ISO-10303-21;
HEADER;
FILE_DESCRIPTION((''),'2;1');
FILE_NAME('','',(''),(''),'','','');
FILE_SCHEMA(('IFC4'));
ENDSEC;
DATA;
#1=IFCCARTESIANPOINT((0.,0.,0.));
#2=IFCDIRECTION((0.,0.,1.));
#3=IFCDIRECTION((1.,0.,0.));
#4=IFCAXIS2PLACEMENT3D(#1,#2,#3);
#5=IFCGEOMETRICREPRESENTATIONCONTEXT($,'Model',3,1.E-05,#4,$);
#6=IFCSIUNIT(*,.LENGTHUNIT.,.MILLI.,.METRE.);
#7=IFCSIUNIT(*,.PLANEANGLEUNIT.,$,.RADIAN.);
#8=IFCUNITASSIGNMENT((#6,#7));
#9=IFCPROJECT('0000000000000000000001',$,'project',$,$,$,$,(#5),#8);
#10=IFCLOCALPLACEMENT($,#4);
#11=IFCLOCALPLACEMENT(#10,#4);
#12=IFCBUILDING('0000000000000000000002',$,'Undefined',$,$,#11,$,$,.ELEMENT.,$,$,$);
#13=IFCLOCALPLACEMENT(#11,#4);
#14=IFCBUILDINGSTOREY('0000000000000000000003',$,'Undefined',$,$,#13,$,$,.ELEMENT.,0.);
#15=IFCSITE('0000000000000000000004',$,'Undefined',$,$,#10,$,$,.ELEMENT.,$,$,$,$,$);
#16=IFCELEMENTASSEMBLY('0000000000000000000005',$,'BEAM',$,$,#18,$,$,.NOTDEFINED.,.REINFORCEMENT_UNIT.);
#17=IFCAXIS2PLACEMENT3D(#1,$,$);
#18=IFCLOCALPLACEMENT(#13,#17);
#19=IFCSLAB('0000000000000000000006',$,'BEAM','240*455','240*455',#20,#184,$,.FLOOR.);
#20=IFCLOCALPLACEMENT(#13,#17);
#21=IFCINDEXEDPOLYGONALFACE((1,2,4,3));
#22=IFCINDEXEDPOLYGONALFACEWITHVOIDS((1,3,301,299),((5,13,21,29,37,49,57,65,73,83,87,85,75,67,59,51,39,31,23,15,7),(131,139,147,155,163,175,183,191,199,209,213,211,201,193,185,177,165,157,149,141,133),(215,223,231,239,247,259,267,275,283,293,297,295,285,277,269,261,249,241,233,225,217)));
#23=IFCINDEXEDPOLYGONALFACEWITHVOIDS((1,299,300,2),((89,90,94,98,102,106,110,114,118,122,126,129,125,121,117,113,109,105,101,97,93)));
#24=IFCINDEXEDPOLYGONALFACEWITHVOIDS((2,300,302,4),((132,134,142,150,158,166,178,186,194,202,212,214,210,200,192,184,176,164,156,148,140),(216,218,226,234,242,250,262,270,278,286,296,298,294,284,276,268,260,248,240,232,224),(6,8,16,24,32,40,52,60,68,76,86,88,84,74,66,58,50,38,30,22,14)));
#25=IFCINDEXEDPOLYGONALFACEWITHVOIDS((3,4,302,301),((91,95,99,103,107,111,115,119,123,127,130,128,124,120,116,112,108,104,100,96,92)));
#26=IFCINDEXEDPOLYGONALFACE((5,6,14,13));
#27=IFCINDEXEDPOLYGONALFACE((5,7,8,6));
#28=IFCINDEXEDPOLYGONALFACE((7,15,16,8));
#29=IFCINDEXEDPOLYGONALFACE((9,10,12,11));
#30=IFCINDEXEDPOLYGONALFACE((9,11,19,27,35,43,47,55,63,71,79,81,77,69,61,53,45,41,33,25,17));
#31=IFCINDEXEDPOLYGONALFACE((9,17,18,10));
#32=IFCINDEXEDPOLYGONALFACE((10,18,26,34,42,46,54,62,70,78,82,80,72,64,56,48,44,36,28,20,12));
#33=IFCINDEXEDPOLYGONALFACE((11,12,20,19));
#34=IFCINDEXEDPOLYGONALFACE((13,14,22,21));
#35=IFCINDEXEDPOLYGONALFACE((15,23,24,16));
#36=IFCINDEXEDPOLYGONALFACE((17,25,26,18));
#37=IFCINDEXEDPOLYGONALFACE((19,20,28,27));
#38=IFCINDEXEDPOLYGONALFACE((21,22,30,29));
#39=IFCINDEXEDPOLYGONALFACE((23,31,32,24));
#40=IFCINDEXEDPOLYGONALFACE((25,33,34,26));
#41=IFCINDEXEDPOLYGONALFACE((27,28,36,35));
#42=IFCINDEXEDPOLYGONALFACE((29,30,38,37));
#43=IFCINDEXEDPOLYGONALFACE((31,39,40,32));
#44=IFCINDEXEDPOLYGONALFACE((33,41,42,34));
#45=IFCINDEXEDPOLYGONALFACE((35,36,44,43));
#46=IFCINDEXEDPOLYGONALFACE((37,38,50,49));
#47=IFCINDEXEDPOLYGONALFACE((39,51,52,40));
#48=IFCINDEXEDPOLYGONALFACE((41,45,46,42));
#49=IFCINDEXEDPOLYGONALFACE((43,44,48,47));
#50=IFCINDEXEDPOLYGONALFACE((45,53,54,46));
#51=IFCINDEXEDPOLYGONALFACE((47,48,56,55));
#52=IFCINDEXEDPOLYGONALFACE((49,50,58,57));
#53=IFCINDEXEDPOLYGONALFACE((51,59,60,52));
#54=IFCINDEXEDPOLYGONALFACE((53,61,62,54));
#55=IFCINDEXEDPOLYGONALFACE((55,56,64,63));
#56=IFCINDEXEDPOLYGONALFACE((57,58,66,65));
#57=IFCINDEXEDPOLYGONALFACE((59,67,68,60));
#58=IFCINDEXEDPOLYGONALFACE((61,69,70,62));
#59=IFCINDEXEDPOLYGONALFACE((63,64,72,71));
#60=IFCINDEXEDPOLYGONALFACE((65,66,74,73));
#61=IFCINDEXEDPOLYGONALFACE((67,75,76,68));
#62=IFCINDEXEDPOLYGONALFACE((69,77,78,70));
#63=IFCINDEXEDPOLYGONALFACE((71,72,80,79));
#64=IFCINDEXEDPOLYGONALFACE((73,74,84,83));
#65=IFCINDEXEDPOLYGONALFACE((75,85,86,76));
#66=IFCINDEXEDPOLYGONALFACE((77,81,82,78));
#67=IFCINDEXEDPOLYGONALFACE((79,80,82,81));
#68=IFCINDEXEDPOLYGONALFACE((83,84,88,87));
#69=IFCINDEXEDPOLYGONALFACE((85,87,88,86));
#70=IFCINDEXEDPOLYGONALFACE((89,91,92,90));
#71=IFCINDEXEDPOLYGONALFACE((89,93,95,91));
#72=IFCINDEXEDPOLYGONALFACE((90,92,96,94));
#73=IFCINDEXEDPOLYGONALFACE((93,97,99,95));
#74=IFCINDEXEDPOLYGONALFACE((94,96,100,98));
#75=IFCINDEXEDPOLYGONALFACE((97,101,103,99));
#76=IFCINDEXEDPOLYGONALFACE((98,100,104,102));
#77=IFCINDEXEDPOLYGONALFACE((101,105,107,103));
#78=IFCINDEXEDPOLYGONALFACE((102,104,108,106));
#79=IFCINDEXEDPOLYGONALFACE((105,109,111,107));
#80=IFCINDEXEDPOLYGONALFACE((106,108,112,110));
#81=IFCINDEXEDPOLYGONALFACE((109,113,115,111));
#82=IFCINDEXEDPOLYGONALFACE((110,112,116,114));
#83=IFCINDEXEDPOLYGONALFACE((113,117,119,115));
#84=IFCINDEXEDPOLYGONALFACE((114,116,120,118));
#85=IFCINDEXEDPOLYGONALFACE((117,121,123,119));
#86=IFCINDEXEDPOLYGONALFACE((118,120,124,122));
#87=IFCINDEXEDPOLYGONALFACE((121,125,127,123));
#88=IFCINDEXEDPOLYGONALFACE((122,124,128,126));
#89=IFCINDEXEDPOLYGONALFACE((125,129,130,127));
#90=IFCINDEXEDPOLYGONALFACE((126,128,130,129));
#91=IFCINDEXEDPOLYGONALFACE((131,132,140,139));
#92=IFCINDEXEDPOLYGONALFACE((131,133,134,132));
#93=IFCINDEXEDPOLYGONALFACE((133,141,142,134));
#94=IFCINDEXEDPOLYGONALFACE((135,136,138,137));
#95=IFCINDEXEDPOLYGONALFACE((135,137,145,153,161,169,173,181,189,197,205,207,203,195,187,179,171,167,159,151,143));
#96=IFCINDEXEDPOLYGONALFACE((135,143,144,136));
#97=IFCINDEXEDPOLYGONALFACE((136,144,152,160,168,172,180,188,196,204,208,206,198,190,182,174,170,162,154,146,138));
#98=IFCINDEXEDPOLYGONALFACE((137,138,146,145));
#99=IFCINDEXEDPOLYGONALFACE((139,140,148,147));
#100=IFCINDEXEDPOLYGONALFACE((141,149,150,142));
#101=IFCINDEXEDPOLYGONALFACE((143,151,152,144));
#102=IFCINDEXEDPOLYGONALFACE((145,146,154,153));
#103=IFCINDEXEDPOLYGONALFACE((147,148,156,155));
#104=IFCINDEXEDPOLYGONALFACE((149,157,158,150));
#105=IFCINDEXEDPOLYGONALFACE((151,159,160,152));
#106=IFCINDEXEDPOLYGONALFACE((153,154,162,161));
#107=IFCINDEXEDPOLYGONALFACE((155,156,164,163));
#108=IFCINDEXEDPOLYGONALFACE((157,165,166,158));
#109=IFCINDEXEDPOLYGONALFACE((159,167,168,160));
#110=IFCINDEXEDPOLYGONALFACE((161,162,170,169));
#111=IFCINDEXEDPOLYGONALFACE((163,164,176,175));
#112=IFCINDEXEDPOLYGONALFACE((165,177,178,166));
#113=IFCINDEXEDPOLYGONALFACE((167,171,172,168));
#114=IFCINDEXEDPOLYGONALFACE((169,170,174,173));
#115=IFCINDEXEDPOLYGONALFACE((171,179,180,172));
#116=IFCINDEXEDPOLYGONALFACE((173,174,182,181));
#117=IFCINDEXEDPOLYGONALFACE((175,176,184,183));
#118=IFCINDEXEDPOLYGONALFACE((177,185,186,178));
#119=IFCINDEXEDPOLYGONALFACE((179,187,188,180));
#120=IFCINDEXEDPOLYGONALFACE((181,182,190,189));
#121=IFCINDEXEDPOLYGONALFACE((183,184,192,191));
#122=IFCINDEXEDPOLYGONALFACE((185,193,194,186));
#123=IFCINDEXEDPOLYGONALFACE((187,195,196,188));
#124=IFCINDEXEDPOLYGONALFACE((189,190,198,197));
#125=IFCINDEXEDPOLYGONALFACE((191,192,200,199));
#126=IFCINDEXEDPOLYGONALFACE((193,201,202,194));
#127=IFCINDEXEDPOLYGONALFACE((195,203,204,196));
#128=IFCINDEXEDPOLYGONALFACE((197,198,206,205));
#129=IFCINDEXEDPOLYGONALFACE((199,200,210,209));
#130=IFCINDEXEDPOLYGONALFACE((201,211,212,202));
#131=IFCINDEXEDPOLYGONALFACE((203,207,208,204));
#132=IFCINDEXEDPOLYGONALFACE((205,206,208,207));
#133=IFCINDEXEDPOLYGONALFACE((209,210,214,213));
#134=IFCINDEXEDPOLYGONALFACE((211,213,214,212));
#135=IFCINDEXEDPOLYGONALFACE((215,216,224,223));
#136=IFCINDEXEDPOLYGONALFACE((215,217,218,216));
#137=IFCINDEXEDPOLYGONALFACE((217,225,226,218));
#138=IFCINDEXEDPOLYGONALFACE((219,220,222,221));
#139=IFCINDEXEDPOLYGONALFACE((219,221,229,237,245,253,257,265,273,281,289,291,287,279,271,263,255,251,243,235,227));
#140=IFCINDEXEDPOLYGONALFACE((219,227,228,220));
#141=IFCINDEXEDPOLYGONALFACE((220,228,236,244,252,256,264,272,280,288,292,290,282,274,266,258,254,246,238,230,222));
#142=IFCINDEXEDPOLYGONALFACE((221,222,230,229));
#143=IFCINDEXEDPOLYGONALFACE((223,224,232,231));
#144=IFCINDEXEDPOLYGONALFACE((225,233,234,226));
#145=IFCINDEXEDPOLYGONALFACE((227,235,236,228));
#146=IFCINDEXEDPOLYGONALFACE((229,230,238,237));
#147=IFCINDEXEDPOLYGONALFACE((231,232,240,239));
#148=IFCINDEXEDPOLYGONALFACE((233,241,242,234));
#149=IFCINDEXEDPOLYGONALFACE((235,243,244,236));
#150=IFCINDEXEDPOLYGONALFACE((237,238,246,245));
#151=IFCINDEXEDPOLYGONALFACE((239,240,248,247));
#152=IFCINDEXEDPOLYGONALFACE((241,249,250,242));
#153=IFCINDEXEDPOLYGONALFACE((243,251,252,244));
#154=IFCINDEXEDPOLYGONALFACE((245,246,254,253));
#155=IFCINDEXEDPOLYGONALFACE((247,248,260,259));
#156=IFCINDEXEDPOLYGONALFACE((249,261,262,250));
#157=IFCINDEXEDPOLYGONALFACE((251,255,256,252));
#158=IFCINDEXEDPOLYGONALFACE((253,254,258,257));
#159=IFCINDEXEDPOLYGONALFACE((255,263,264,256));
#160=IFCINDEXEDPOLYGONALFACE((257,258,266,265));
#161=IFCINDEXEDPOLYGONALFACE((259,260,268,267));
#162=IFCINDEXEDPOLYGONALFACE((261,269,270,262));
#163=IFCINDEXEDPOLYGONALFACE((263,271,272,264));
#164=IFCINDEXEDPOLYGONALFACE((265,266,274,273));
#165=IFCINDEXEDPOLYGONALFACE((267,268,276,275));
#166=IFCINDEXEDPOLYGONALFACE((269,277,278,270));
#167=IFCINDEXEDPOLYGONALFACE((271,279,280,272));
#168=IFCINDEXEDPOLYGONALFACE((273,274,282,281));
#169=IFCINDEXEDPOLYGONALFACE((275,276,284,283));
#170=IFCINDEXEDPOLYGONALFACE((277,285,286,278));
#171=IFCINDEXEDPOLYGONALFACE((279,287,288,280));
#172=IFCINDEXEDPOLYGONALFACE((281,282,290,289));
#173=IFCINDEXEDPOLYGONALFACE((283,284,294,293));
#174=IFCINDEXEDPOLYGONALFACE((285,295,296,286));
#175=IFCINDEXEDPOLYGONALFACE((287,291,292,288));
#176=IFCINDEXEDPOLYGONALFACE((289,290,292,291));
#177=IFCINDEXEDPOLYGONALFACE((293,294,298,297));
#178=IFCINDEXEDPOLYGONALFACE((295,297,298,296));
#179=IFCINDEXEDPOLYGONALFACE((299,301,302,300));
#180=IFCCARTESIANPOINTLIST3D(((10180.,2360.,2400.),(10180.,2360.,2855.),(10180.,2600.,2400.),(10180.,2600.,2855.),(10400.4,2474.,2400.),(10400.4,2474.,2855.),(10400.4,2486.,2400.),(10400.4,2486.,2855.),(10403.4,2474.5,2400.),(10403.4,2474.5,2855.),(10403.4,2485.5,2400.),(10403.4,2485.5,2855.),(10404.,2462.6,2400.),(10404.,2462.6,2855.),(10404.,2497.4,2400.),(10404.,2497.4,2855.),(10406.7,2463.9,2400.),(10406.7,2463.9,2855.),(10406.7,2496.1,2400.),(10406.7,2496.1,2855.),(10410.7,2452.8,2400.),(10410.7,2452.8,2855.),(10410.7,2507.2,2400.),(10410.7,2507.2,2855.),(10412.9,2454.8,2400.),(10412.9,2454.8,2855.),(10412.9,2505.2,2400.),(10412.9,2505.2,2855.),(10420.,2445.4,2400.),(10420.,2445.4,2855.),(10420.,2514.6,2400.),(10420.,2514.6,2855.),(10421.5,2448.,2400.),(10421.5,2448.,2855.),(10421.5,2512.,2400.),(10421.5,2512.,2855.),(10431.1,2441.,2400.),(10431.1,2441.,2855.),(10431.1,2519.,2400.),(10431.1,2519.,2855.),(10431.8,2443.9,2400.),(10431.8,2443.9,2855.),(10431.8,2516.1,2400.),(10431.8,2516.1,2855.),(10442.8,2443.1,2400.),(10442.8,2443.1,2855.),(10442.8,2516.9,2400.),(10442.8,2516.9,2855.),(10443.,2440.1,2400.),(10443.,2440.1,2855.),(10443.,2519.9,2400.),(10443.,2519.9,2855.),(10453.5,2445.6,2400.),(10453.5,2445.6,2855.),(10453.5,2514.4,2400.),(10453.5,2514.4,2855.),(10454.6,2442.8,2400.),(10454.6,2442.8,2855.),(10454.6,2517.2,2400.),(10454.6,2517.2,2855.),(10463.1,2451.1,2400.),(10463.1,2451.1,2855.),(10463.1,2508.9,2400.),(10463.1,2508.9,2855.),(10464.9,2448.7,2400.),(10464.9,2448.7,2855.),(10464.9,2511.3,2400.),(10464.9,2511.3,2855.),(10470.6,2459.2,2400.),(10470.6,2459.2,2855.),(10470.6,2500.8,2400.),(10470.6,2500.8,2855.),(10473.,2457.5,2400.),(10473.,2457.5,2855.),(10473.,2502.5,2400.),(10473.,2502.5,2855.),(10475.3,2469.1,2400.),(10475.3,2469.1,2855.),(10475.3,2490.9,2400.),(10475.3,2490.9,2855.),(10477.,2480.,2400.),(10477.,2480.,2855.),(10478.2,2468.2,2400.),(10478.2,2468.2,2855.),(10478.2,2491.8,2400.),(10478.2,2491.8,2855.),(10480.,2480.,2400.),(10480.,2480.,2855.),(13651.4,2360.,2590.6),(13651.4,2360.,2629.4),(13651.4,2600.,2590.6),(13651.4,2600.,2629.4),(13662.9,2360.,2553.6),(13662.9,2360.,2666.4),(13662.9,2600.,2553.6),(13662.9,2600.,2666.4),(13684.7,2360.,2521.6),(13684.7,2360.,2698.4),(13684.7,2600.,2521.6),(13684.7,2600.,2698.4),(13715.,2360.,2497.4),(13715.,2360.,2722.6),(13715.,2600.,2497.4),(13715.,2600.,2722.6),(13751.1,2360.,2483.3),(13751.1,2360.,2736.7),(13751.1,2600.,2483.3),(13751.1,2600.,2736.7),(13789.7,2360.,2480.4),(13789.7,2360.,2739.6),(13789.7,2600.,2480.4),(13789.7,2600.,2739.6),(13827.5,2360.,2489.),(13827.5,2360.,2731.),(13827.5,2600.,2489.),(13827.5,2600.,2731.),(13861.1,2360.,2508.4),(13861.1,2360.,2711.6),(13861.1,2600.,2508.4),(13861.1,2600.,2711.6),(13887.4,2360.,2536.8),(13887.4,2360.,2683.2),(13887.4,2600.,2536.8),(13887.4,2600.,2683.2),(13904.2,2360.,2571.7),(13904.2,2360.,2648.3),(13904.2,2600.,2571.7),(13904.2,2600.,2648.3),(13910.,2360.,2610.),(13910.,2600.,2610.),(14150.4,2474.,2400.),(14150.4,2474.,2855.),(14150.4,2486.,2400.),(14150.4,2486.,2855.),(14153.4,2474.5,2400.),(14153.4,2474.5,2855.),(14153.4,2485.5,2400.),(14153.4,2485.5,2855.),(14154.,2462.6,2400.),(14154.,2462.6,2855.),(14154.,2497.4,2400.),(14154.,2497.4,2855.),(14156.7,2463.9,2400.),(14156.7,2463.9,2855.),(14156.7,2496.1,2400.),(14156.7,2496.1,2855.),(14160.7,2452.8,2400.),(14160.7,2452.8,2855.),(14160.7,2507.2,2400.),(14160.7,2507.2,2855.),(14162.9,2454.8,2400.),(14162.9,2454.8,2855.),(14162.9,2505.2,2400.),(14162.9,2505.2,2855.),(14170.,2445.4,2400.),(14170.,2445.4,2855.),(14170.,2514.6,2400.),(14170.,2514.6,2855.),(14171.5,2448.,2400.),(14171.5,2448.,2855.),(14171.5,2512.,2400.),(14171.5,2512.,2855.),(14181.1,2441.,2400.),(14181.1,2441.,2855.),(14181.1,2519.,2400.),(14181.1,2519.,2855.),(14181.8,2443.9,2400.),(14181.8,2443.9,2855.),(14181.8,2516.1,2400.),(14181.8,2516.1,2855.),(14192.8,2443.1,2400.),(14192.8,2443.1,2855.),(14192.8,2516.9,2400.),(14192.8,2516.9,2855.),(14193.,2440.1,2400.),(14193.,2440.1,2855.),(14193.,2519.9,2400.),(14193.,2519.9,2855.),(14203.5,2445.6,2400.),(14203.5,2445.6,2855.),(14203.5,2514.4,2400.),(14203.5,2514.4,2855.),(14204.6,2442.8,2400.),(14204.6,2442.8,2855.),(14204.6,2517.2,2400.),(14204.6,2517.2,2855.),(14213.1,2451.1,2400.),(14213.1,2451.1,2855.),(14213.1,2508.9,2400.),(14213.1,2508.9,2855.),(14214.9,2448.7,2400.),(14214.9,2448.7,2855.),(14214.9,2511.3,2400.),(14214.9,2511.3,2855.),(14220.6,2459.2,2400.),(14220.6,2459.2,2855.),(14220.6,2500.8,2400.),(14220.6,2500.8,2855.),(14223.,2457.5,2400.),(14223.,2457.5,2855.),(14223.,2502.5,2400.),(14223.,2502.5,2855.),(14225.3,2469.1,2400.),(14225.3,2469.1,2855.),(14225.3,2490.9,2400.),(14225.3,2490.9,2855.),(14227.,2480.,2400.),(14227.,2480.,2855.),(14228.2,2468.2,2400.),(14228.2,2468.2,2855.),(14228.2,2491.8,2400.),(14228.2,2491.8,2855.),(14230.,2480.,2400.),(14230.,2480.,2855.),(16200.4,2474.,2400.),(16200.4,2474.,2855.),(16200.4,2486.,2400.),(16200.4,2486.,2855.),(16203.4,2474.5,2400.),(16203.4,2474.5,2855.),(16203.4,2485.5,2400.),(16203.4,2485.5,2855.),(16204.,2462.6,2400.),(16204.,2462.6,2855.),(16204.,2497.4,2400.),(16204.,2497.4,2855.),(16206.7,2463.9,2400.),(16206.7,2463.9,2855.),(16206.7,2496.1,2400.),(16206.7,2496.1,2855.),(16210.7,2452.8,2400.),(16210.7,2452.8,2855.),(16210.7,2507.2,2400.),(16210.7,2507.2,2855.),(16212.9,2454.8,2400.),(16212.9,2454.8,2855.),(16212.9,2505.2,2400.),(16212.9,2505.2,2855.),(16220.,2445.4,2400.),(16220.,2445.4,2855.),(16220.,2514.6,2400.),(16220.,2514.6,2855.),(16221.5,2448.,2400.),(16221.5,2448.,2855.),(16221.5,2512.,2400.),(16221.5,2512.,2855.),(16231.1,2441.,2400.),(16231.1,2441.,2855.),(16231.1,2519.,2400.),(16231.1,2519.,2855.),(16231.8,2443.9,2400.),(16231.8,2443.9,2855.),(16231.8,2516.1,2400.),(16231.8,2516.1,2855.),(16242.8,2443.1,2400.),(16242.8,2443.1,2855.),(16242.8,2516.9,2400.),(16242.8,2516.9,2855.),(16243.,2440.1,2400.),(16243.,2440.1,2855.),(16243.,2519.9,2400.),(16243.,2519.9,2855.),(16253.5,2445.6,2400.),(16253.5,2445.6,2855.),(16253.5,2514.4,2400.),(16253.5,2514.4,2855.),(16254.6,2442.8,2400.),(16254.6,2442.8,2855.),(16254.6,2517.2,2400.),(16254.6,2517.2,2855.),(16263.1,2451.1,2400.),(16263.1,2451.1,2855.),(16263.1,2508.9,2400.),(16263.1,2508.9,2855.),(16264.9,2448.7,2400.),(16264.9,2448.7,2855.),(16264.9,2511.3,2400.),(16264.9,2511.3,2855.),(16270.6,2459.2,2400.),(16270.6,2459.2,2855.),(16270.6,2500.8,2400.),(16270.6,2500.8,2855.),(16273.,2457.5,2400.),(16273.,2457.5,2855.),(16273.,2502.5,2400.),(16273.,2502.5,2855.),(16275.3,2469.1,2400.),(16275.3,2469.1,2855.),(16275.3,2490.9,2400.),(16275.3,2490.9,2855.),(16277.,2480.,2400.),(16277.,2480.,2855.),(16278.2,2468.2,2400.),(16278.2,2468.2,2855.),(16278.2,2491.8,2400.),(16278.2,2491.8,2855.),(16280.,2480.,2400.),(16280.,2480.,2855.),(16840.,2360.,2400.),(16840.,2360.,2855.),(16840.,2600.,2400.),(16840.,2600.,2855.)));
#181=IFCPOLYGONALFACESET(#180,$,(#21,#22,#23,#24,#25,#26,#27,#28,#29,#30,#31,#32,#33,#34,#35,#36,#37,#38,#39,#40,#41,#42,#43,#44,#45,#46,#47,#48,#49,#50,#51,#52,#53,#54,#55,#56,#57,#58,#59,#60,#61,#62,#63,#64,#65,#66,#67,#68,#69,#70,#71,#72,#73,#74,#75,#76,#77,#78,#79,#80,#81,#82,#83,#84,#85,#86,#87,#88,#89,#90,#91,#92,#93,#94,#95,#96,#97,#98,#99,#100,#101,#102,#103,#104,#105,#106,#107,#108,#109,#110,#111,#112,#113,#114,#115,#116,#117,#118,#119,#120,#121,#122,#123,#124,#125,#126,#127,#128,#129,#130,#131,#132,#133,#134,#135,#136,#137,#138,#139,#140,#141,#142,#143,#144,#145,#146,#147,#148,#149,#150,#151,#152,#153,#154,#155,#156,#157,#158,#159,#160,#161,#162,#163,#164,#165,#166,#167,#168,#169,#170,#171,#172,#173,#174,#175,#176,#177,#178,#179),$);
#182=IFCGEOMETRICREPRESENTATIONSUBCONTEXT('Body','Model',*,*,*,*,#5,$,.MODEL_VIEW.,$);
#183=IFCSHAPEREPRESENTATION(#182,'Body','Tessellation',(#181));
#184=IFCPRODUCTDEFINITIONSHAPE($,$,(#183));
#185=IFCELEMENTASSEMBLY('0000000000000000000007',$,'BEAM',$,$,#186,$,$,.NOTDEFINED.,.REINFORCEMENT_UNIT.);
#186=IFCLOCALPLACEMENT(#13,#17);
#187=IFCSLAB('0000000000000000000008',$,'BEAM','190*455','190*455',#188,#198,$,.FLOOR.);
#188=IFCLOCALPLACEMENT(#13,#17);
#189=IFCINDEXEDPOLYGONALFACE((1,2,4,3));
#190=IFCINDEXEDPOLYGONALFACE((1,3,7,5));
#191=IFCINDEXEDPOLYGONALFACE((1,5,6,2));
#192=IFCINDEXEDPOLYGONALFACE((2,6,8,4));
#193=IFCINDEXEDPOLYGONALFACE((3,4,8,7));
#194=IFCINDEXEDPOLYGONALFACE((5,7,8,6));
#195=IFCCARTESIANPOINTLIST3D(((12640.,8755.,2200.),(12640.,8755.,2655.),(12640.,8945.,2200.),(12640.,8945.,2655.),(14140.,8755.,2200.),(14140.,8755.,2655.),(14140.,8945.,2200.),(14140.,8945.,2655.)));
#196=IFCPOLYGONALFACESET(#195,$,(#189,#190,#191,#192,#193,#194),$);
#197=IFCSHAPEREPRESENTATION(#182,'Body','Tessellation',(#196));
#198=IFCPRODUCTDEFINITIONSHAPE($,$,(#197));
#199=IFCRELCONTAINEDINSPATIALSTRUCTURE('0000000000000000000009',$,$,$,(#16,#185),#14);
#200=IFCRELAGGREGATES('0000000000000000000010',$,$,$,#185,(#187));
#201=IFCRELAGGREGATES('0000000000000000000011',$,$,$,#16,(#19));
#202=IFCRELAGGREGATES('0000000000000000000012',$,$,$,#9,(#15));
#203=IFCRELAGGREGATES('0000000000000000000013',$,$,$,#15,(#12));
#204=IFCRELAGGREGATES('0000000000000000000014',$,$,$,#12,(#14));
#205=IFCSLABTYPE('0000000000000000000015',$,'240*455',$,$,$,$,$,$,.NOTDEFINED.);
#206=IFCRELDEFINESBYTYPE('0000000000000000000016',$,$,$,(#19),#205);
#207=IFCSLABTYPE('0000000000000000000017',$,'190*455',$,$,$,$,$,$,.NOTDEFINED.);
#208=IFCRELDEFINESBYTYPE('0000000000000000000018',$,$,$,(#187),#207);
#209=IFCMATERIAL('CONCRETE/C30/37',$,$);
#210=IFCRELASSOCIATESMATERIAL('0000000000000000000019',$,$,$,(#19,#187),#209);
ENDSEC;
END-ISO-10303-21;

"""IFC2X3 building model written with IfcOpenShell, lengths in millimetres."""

from ifc_helpers import new_model, si_unit, frame, origin_with_axes, origin_2d_with_axis, place, context, subcontext, project, spatial, polyline, circle, hollow_circle, outline, extrude, boolean, material, type_object, element, aggregate, save


model = new_model("IFC2X3")

# Units and contexts
model_context = context("Model", 3, precision=1e-05, world=origin_with_axes())
body_context = subcontext(model_context, "Body", "Model", "MODEL_VIEW")
ifc_project = project(units=[si_unit("LENGTHUNIT", "METRE", prefix="MILLI"), si_unit("PLANEANGLEUNIT", "RADIAN")], contexts=[model_context])

# Site, building, storey
site_placement = place(None, origin_with_axes())
site = spatial("IfcSite", under=ifc_project, at=site_placement, Name="Undefined", CompositionType="ELEMENT")
building_placement = place(site_placement, origin_with_axes())
building = spatial("IfcBuilding", under=site, at=building_placement, Name="Undefined", CompositionType="ELEMENT")
storey_placement = place(building_placement, origin_with_axes())
storey = spatial("IfcBuildingStorey", under=building, at=storey_placement, Name="Undefined", CompositionType="ELEMENT", Elevation=0.0)

# Element assembly
assembly_1_placement = place(storey_placement, origin_with_axes())
assembly_1 = element("IfcElementAssembly", 1, at=assembly_1_placement, inside=storey, Name="BEAM", AssemblyPlace="NOTDEFINED", PredefinedType="REINFORCEMENT_UNIT")

# Slab
ifc_material_1 = material(Name="CONCRETE/C30/37")
slab_type_1 = type_object("IfcSlabType", Name="240*455", PredefinedType="NOTDEFINED")
slab_1_placement = place(assembly_1_placement, frame((10180.0, 2480.0, 2400.0), z_axis=(0.0, 1.0, 0.0), x_axis=(0.0, 0.0, 1.0)))
slab_1 = element("IfcSlab", 2, at=slab_1_placement, type_object=slab_type_1, material=ifc_material_1, Name="BEAM", Description="240*455", ObjectType="240*455", PredefinedType="FLOOR", context=body_context, shape_type="CSG", body=[
    boolean("DIFFERENCE", boolean("DIFFERENCE", boolean("DIFFERENCE", boolean("DIFFERENCE", extrude(outline(polyline([(0.0, 0.0), (455.0, 0.0), (455.0, 6660.0), (0.0, 6660.0), (0.0, 0.0)])), frame((0.0, 0.0, -120.0), z_axis=(0.0, 0.0, 1.0), x_axis=(1.0, 0.0, 0.0)), (0.0, 0.0, 1.0), 240.0), extrude(hollow_circle(Radius=40.0, WallThickness=3.0, at=origin_2d_with_axis()), frame((455.0, 6060.0, 0.0), z_axis=(-1.0, 0.0, 0.0), x_axis=(0.0, 1.0, 0.0)), (0.0, 0.0, 1.0), 455.0)), extrude(hollow_circle(Radius=40.0, WallThickness=3.0, at=origin_2d_with_axis()), frame((455.0, 260.0, 0.0), z_axis=(-1.0, 0.0, 0.0), x_axis=(0.0, 1.0, 0.0)), (0.0, 0.0, 1.0), 455.0)), extrude(hollow_circle(Radius=40.0, WallThickness=3.0, at=origin_2d_with_axis()), frame((455.0, 4010.0, 0.0), z_axis=(-1.0, 0.0, 0.0), x_axis=(0.0, 1.0, 0.0)), (0.0, 0.0, 1.0), 455.0)), extrude(circle(Radius=130.0, at=origin_2d_with_axis()), frame((210.0, 3600.0, 125.0), z_axis=(0.0, 0.0, -1.0), x_axis=(0.0, 1.0, 0.0)), (0.0, 0.0, 1.0), 250.0)),
])

# Element assembly, slab
assembly_2_placement = place(storey_placement, origin_with_axes())
assembly_2 = element("IfcElementAssembly", 3, at=assembly_2_placement, inside=storey, Name="BEAM", AssemblyPlace="NOTDEFINED", PredefinedType="REINFORCEMENT_UNIT")
slab_type_2 = type_object("IfcSlabType", Name="190*455", PredefinedType="NOTDEFINED")
slab_2_placement = place(assembly_2_placement, frame((12640.0, 8850.0, 2200.0), z_axis=(0.0, 1.0, 0.0), x_axis=(0.0, 0.0, 1.0)))
slab_2 = element("IfcSlab", 4, at=slab_2_placement, type_object=slab_type_2, material=ifc_material_1, Name="BEAM", Description="190*455", ObjectType="190*455", PredefinedType="FLOOR", context=body_context, shape_type="SweptSolid", body=[
    extrude(outline(polyline([(0.0, 0.0), (455.0, 0.0), (455.0, 1500.0), (0.0, 1500.0), (0.0, 0.0)])), frame((0.0, 0.0, -95.0), z_axis=(0.0, 0.0, 1.0), x_axis=(1.0, 0.0, 0.0)), (0.0, 0.0, 1.0), 190.0),
])

aggregate(assembly_2, [slab_2])
aggregate(assembly_1, [slab_1])

save(model, "model.ifc")
